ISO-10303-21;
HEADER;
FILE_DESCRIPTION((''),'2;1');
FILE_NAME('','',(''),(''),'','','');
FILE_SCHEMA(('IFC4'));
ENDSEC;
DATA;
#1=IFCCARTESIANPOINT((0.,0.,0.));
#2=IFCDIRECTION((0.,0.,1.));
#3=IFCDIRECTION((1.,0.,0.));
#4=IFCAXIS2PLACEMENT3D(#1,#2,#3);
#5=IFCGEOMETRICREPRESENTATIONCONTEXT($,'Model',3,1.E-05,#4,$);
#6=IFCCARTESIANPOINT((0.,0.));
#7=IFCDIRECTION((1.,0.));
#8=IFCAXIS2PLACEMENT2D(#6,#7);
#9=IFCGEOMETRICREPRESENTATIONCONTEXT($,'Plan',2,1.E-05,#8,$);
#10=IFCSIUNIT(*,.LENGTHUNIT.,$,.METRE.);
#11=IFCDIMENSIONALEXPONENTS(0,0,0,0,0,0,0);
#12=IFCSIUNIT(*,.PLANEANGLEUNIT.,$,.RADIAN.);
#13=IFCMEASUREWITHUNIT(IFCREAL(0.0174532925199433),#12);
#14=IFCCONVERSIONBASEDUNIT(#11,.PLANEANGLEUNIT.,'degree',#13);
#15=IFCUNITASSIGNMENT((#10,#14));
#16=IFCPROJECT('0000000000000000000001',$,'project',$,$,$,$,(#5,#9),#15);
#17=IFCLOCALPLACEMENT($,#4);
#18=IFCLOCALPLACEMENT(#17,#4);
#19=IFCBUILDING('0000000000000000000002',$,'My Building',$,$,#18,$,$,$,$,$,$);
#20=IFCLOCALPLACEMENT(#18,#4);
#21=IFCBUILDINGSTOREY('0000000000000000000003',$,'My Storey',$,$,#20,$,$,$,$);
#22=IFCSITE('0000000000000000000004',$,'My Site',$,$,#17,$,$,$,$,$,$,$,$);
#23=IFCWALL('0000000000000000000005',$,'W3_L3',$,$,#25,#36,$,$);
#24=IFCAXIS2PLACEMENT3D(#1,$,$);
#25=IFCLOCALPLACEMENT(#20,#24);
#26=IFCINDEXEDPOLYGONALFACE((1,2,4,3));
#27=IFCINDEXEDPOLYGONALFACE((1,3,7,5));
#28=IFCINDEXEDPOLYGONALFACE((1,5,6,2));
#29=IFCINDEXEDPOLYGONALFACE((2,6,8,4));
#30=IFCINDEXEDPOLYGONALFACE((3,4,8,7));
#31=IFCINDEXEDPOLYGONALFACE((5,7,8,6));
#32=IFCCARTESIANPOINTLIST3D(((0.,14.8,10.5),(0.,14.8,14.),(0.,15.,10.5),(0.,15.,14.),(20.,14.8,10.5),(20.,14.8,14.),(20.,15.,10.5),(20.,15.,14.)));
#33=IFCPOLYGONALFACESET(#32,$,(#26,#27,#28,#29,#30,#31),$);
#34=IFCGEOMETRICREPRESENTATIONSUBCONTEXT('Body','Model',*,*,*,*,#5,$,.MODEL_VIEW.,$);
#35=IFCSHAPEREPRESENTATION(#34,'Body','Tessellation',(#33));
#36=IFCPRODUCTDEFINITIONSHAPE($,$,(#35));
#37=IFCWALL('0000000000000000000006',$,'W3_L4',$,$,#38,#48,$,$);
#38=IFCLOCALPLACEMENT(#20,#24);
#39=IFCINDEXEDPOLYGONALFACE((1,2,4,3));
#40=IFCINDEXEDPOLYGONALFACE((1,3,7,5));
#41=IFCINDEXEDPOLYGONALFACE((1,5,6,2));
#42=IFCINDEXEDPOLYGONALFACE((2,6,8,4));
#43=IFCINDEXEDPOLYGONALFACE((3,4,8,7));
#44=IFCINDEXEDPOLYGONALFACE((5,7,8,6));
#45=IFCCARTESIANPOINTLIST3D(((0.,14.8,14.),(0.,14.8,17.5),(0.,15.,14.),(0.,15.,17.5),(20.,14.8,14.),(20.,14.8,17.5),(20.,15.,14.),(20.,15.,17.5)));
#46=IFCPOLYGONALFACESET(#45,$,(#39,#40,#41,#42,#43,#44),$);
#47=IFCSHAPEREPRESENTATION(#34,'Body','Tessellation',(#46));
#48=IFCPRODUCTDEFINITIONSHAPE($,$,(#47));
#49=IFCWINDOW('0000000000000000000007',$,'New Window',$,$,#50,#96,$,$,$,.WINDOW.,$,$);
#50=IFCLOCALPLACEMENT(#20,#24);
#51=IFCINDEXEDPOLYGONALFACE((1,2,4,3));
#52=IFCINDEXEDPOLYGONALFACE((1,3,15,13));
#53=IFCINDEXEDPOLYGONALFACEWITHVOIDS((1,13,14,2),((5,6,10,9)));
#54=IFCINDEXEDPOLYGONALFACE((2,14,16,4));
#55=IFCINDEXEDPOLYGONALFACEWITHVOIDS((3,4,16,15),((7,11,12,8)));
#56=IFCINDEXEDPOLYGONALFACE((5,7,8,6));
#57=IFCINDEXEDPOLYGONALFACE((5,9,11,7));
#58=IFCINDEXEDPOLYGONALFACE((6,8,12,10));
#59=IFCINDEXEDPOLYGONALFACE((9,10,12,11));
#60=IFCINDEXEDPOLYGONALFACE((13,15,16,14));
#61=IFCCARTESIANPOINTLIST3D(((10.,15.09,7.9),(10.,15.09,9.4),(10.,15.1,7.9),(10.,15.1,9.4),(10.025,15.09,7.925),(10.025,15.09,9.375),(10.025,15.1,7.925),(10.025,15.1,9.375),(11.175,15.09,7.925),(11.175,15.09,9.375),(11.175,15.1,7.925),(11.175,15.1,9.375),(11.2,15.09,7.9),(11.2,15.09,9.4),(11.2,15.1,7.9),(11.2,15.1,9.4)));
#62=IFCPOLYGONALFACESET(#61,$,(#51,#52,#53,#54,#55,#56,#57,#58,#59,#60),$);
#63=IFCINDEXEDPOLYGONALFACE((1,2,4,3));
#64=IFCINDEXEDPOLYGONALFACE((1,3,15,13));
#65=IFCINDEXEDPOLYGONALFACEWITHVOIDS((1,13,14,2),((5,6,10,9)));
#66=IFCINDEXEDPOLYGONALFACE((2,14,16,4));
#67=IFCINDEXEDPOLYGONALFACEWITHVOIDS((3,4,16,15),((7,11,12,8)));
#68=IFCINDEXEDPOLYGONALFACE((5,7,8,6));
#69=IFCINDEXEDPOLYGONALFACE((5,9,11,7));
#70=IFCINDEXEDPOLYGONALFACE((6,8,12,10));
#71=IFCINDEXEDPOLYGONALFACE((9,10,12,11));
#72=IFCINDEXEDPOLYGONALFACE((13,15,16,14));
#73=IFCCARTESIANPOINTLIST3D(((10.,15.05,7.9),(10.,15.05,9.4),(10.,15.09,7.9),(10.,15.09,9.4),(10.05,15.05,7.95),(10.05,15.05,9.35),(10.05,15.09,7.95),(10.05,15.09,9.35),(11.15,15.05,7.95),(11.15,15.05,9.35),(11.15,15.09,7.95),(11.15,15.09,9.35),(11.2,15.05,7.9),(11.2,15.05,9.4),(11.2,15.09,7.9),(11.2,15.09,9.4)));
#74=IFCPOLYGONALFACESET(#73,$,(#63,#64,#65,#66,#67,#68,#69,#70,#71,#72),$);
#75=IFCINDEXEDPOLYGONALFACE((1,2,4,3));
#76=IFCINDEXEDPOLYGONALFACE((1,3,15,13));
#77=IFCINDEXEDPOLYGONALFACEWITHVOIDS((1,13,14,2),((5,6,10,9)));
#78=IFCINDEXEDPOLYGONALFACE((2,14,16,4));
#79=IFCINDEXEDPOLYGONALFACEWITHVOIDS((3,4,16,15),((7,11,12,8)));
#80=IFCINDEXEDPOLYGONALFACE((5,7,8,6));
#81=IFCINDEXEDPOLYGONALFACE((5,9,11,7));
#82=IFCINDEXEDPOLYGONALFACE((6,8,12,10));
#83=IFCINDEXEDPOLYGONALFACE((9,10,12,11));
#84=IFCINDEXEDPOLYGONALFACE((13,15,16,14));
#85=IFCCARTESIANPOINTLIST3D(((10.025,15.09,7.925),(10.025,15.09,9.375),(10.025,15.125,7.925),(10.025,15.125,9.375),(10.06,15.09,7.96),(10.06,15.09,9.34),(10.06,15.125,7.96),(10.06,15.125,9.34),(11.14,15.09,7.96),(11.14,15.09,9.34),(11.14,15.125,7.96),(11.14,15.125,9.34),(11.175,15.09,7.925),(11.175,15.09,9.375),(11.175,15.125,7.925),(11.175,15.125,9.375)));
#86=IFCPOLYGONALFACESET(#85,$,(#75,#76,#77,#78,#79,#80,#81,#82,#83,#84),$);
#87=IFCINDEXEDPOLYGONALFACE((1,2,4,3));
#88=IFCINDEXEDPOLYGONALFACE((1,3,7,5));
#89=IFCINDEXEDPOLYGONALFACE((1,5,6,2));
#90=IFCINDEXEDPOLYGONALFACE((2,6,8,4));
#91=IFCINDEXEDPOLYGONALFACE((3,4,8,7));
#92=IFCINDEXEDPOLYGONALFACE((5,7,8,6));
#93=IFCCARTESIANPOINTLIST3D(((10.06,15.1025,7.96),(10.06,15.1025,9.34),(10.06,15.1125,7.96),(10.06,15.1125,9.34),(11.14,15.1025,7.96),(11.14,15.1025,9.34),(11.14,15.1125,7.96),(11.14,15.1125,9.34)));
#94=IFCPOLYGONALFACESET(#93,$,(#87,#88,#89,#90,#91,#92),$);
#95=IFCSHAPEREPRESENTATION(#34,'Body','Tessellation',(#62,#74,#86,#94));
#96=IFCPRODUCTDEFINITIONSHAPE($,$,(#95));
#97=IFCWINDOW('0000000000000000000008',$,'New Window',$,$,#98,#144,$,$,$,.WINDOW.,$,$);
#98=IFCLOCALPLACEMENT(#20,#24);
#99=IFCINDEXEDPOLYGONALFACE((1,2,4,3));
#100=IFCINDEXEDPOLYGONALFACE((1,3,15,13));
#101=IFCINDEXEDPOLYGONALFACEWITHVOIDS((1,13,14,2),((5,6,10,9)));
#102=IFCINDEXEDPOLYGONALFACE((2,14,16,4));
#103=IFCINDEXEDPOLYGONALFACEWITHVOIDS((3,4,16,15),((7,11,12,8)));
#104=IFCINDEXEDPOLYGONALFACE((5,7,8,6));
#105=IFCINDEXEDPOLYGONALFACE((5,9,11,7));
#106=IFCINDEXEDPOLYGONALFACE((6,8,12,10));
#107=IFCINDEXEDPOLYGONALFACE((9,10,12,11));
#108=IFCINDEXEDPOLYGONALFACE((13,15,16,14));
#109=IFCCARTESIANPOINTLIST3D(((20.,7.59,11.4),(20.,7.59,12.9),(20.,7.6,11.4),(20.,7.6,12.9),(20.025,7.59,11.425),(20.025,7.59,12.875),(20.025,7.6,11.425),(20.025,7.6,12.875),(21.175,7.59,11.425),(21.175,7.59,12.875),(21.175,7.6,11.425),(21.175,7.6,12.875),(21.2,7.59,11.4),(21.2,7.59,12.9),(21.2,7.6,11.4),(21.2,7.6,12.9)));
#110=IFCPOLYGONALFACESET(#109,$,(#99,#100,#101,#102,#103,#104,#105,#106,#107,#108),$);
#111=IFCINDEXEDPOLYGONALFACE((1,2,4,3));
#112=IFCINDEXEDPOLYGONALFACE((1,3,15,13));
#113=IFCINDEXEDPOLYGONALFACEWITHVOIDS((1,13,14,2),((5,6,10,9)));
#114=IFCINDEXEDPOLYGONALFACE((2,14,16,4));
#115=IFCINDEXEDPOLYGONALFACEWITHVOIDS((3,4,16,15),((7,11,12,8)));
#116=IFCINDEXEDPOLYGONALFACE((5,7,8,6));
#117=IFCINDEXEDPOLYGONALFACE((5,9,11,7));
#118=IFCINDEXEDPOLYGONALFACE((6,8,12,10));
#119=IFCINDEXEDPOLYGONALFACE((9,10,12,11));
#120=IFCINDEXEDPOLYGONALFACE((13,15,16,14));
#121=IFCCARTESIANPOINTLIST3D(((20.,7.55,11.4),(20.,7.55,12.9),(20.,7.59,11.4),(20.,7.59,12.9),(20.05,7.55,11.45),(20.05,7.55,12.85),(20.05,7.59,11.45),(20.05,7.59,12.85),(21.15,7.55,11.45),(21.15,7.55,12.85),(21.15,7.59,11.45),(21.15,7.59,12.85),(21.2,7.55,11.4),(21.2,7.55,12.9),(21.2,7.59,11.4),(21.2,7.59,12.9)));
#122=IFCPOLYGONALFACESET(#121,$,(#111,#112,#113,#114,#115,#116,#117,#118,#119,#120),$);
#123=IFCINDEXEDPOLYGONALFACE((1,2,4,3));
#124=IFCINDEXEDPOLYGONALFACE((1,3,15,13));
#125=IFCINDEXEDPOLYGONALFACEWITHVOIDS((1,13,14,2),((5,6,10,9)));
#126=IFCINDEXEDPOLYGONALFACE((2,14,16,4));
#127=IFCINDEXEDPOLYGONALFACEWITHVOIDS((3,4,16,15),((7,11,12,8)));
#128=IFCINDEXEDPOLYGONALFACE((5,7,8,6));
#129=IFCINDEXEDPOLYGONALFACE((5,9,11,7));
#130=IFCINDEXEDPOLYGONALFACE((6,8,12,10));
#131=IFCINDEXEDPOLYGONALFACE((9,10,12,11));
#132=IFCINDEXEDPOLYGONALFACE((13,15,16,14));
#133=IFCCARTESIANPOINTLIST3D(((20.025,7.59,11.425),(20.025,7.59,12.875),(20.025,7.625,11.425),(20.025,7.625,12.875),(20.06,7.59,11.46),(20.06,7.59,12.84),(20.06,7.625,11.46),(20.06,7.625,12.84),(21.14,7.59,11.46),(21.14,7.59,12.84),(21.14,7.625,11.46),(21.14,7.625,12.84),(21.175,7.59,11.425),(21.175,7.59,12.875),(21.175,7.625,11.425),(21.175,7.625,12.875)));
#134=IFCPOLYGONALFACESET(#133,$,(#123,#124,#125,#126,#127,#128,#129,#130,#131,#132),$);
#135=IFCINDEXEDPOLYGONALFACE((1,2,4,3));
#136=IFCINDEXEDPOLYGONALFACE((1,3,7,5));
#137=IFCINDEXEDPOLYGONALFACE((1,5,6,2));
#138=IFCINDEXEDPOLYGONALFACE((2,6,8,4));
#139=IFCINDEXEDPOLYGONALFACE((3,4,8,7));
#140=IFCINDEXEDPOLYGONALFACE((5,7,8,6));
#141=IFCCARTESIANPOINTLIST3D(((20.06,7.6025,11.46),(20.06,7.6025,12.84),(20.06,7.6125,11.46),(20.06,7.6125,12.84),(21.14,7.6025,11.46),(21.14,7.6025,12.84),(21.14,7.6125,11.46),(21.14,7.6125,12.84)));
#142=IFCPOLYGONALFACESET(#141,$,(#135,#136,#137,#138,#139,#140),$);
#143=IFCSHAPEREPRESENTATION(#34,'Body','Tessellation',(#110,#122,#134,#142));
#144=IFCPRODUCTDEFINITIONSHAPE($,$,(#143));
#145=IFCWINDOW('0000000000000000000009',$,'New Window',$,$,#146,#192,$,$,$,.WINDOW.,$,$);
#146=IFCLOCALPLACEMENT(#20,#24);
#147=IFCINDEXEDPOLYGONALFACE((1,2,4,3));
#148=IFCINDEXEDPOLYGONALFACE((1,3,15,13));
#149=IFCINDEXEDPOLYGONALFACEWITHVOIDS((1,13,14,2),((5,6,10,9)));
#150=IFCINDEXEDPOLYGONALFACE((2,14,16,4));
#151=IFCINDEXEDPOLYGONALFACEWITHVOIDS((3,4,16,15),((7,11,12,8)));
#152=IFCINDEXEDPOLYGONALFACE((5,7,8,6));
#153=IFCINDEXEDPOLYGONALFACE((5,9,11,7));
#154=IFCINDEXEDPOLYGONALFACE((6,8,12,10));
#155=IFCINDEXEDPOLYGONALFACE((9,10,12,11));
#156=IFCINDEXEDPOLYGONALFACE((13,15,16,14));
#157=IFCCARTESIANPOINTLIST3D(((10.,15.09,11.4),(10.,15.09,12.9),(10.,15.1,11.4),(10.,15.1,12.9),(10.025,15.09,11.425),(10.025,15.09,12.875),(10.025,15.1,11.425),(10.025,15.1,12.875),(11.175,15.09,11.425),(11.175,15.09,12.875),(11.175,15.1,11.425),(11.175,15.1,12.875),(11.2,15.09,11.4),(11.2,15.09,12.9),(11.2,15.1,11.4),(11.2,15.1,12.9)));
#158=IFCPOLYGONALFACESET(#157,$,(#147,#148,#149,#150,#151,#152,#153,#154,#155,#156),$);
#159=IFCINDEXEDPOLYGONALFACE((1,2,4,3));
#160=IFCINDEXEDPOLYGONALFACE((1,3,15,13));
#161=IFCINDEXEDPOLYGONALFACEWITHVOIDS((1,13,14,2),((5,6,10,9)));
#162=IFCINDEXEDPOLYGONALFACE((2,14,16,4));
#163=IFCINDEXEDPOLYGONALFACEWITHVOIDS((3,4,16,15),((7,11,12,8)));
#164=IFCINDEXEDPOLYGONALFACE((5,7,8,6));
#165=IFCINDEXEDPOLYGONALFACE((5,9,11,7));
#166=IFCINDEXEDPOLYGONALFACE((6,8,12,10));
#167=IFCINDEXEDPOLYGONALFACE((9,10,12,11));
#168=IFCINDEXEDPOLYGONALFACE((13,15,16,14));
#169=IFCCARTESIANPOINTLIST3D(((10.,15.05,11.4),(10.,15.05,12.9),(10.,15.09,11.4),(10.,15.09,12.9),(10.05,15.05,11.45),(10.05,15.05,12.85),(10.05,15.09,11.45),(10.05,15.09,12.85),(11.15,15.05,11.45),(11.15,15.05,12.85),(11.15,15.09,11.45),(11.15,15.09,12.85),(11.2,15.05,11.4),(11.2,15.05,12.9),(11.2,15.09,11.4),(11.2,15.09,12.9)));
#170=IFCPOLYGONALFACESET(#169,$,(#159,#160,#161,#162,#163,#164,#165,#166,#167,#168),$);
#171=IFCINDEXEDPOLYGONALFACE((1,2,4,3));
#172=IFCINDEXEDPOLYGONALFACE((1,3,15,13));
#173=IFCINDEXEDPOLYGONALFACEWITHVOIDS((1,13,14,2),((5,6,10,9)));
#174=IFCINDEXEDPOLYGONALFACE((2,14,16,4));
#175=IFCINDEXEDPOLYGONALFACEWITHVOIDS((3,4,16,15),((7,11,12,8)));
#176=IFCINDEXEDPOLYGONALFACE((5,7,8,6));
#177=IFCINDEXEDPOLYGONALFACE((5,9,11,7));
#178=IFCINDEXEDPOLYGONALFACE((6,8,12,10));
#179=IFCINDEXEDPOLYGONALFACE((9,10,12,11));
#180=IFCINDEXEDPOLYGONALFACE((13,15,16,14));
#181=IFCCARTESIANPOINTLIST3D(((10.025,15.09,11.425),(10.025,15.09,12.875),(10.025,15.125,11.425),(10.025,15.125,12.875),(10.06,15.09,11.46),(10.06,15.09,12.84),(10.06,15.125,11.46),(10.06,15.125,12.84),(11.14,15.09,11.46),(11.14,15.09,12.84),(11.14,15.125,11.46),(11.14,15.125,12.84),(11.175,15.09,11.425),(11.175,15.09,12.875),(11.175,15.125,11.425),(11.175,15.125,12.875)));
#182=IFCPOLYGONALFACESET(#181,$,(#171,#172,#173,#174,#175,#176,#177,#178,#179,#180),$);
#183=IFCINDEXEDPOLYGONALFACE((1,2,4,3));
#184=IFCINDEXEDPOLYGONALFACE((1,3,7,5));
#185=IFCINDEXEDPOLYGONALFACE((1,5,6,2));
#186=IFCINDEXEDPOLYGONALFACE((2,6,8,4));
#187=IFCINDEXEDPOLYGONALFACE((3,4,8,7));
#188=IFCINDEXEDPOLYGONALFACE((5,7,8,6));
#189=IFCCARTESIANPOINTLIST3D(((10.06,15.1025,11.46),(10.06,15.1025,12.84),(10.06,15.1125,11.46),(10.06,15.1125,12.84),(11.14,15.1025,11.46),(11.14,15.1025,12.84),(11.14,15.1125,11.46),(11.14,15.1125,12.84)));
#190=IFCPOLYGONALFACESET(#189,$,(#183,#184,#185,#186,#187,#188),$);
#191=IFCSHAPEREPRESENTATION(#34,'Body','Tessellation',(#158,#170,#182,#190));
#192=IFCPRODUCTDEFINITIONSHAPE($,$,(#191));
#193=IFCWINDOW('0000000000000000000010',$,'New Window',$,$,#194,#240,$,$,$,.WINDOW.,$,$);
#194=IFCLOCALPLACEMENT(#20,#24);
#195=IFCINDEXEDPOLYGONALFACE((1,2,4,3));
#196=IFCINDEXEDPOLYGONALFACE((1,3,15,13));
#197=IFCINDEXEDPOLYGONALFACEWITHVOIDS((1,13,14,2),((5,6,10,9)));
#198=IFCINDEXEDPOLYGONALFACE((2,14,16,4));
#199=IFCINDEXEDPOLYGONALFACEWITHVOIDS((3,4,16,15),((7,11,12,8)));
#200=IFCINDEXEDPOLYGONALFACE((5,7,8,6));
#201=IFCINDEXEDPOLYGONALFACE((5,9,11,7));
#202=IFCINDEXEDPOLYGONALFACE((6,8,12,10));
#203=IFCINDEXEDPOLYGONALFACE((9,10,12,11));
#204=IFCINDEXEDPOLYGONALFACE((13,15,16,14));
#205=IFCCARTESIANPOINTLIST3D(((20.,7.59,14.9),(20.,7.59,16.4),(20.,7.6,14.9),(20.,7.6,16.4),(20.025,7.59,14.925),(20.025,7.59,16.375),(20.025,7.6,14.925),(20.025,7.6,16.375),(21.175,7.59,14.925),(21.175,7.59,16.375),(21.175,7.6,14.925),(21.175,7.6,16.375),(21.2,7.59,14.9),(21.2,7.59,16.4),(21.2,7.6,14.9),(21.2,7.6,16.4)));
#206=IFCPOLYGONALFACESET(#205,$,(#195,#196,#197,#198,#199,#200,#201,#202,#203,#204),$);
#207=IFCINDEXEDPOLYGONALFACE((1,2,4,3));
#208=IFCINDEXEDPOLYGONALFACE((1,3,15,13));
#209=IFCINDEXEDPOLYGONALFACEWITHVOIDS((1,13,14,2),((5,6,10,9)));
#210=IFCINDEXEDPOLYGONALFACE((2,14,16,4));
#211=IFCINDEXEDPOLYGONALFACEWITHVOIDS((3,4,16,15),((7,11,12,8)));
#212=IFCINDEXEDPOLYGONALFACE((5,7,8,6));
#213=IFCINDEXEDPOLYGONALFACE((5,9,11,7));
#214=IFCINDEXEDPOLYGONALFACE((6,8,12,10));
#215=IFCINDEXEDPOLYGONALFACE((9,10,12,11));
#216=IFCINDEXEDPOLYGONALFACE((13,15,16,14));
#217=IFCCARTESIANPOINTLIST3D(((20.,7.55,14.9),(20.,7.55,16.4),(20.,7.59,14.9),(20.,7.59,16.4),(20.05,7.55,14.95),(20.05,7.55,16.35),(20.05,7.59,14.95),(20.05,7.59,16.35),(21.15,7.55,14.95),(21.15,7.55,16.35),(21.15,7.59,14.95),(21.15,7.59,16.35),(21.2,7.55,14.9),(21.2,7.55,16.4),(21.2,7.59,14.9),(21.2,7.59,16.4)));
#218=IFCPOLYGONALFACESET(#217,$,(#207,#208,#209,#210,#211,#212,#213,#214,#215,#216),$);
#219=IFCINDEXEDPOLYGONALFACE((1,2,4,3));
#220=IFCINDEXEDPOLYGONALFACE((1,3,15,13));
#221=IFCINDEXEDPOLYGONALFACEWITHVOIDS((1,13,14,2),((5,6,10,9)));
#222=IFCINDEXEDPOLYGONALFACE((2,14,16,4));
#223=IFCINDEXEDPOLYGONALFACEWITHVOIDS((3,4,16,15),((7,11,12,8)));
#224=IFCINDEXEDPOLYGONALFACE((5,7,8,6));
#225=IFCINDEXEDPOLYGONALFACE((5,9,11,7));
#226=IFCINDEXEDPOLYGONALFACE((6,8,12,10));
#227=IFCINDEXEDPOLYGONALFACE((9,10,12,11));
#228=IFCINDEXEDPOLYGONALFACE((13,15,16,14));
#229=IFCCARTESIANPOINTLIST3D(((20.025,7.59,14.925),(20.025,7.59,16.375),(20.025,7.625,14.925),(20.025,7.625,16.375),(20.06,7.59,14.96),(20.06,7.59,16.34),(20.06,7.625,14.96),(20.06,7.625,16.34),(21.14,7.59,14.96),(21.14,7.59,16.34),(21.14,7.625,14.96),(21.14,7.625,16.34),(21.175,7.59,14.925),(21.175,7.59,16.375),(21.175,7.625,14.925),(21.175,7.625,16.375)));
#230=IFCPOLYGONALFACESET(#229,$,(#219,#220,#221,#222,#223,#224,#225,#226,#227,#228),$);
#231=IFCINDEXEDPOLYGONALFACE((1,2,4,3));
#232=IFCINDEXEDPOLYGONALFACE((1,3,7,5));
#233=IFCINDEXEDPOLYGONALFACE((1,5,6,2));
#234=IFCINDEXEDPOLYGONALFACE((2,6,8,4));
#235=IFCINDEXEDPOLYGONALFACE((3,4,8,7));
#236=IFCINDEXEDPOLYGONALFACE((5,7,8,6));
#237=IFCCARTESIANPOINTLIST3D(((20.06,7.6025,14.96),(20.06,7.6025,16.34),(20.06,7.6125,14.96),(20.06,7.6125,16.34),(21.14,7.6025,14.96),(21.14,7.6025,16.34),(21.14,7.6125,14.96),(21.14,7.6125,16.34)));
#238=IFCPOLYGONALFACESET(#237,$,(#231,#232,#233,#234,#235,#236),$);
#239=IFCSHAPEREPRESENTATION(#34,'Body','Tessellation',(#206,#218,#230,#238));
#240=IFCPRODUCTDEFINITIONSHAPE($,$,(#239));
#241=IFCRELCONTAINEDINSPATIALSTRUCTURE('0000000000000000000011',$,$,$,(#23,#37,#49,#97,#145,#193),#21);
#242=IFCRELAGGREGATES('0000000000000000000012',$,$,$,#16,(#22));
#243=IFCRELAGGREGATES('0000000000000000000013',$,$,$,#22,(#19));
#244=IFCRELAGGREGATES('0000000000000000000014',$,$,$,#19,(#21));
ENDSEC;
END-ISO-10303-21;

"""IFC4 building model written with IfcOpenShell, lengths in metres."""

from ifc_helpers import new_model, entity, si_unit, converted_unit, frame, origin_with_axes, origin_2d_with_axis, place, context, subcontext, project, spatial, line, indexed_curve, outline, extrude, element, save


model = new_model("IFC4")

# Units and contexts
model_context = context("Model", 3, precision=1e-05, world=origin_with_axes())
plan_context = context("Plan", 2, precision=1e-05, world=origin_2d_with_axis())
body_context = subcontext(model_context, "Body", "Model", "MODEL_VIEW")
ifc_project = project(units=[si_unit("LENGTHUNIT", "METRE"), converted_unit("PLANEANGLEUNIT", "degree", entity("IfcReal", 0.0174532925199433), si_unit("PLANEANGLEUNIT", "RADIAN"), dimensions=[0, 0, 0, 0, 0, 0, 0])], contexts=[model_context, plan_context])

# Site, building, storey
site_placement = place(None, origin_with_axes())
site = spatial("IfcSite", under=ifc_project, at=site_placement, Name="My Site")
building_placement = place(site_placement, origin_with_axes())
building = spatial("IfcBuilding", under=site, at=building_placement, Name="My Building")
storey_placement = place(building_placement, origin_with_axes())
storey = spatial("IfcBuildingStorey", under=building, at=storey_placement, Name="My Storey")

# Walls
for number, where, z_axis, x_axis, name in (
    (1, (20.0, 15.0, 10.5), (0.0, 0.0, 1.0), (-1.0, 0.0, 0.0), "W3_L3"),
    (2, (20.0, 15.0, 14.0), (0.0, 0.0, 1.0), (-1.0, 0.0, 0.0), "W3_L4"),
):
    element("IfcWall", number, at=place(storey_placement, frame(where, z_axis=z_axis, x_axis=x_axis)), inside=storey, Name=name, context=body_context, shape_type="SweptSolid", body=[
        extrude(outline(indexed_curve([(0.0, 0.0), (0.0, 0.2), (20.0, 0.2), (20.0, 0.0), (0.0, 0.0)], self_intersect=False)), origin_with_axes(), (0.0, 0.0, 1.0), 3.5),
    ])

# Windows
for number, where, z_axis, x_axis, name in (
    (3, (10.0, 15.0, 7.9), (0.0, 0.0, 1.0), (1.0, 0.0, 0.0), "New Window"),
    (4, (20.0, 7.5, 11.4), (0.0, 0.0, 1.0), (1.0, 0.0, 0.0), "New Window"),
    (5, (10.0, 15.0, 11.4), (0.0, 0.0, 1.0), (1.0, 0.0, 0.0), "New Window"),
    (6, (20.0, 7.5, 14.9), (0.0, 0.0, 1.0), (1.0, 0.0, 0.0), "New Window"),
):
    element("IfcWindow", number, at=place(storey_placement, frame(where, z_axis=z_axis, x_axis=x_axis)), inside=storey, Name=name, PredefinedType="WINDOW", context=body_context, shape_type="SweptSolid", body=[
        extrude(outline(indexed_curve([(0.0, 0.0), (1.2, 0.0), (1.2, 1.5), (0.0, 1.5)], segments=[line(1, 2, 3, 4, 1)]), holes=[indexed_curve([(0.025, 0.025), (1.175, 0.025), (1.175, 1.475), (0.025, 1.475)], segments=[line(1, 2, 3, 4, 1)])]), frame((0.0, 0.09, 0.0), z_axis=(0.0, -1.0, 0.0), x_axis=(1.0, 0.0, 0.0)), (0.0, 0.0, -1.0), 0.01),
        extrude(outline(indexed_curve([(0.0, 0.0), (1.2, 0.0), (1.2, 1.5), (0.0, 1.5)], segments=[line(1, 2, 3, 4, 1)]), holes=[indexed_curve([(0.05, 0.05), (1.15, 0.05), (1.15, 1.45), (0.05, 1.45)], segments=[line(1, 2, 3, 4, 1)])]), frame((0.0, 0.05, 0.0), z_axis=(0.0, -1.0, 0.0), x_axis=(1.0, 0.0, 0.0)), (0.0, 0.0, -1.0), 0.04),
        extrude(outline(indexed_curve([(0.0, 0.0), (1.15, 0.0), (1.15, 1.45), (0.0, 1.45)], segments=[line(1, 2, 3, 4, 1)]), holes=[indexed_curve([(0.035, 0.035), (1.115, 0.035), (1.115, 1.415), (0.035, 1.415)], segments=[line(1, 2, 3, 4, 1)])]), frame((0.025, 0.09, 0.025), z_axis=(0.0, -1.0, 0.0), x_axis=(1.0, 0.0, 0.0)), (0.0, 0.0, -1.0), 0.035),
        extrude(outline(indexed_curve([(0.035, 0.035), (1.115, 0.035), (1.115, 1.415), (0.035, 1.415)], segments=[line(1, 2, 3, 4, 1)])), frame((0.025, 0.1025, 0.025), z_axis=(0.0, -1.0, 0.0), x_axis=(1.0, 0.0, 0.0)), (0.0, 0.0, -1.0), 0.01),
    ])

save(model, "model.ifc")
